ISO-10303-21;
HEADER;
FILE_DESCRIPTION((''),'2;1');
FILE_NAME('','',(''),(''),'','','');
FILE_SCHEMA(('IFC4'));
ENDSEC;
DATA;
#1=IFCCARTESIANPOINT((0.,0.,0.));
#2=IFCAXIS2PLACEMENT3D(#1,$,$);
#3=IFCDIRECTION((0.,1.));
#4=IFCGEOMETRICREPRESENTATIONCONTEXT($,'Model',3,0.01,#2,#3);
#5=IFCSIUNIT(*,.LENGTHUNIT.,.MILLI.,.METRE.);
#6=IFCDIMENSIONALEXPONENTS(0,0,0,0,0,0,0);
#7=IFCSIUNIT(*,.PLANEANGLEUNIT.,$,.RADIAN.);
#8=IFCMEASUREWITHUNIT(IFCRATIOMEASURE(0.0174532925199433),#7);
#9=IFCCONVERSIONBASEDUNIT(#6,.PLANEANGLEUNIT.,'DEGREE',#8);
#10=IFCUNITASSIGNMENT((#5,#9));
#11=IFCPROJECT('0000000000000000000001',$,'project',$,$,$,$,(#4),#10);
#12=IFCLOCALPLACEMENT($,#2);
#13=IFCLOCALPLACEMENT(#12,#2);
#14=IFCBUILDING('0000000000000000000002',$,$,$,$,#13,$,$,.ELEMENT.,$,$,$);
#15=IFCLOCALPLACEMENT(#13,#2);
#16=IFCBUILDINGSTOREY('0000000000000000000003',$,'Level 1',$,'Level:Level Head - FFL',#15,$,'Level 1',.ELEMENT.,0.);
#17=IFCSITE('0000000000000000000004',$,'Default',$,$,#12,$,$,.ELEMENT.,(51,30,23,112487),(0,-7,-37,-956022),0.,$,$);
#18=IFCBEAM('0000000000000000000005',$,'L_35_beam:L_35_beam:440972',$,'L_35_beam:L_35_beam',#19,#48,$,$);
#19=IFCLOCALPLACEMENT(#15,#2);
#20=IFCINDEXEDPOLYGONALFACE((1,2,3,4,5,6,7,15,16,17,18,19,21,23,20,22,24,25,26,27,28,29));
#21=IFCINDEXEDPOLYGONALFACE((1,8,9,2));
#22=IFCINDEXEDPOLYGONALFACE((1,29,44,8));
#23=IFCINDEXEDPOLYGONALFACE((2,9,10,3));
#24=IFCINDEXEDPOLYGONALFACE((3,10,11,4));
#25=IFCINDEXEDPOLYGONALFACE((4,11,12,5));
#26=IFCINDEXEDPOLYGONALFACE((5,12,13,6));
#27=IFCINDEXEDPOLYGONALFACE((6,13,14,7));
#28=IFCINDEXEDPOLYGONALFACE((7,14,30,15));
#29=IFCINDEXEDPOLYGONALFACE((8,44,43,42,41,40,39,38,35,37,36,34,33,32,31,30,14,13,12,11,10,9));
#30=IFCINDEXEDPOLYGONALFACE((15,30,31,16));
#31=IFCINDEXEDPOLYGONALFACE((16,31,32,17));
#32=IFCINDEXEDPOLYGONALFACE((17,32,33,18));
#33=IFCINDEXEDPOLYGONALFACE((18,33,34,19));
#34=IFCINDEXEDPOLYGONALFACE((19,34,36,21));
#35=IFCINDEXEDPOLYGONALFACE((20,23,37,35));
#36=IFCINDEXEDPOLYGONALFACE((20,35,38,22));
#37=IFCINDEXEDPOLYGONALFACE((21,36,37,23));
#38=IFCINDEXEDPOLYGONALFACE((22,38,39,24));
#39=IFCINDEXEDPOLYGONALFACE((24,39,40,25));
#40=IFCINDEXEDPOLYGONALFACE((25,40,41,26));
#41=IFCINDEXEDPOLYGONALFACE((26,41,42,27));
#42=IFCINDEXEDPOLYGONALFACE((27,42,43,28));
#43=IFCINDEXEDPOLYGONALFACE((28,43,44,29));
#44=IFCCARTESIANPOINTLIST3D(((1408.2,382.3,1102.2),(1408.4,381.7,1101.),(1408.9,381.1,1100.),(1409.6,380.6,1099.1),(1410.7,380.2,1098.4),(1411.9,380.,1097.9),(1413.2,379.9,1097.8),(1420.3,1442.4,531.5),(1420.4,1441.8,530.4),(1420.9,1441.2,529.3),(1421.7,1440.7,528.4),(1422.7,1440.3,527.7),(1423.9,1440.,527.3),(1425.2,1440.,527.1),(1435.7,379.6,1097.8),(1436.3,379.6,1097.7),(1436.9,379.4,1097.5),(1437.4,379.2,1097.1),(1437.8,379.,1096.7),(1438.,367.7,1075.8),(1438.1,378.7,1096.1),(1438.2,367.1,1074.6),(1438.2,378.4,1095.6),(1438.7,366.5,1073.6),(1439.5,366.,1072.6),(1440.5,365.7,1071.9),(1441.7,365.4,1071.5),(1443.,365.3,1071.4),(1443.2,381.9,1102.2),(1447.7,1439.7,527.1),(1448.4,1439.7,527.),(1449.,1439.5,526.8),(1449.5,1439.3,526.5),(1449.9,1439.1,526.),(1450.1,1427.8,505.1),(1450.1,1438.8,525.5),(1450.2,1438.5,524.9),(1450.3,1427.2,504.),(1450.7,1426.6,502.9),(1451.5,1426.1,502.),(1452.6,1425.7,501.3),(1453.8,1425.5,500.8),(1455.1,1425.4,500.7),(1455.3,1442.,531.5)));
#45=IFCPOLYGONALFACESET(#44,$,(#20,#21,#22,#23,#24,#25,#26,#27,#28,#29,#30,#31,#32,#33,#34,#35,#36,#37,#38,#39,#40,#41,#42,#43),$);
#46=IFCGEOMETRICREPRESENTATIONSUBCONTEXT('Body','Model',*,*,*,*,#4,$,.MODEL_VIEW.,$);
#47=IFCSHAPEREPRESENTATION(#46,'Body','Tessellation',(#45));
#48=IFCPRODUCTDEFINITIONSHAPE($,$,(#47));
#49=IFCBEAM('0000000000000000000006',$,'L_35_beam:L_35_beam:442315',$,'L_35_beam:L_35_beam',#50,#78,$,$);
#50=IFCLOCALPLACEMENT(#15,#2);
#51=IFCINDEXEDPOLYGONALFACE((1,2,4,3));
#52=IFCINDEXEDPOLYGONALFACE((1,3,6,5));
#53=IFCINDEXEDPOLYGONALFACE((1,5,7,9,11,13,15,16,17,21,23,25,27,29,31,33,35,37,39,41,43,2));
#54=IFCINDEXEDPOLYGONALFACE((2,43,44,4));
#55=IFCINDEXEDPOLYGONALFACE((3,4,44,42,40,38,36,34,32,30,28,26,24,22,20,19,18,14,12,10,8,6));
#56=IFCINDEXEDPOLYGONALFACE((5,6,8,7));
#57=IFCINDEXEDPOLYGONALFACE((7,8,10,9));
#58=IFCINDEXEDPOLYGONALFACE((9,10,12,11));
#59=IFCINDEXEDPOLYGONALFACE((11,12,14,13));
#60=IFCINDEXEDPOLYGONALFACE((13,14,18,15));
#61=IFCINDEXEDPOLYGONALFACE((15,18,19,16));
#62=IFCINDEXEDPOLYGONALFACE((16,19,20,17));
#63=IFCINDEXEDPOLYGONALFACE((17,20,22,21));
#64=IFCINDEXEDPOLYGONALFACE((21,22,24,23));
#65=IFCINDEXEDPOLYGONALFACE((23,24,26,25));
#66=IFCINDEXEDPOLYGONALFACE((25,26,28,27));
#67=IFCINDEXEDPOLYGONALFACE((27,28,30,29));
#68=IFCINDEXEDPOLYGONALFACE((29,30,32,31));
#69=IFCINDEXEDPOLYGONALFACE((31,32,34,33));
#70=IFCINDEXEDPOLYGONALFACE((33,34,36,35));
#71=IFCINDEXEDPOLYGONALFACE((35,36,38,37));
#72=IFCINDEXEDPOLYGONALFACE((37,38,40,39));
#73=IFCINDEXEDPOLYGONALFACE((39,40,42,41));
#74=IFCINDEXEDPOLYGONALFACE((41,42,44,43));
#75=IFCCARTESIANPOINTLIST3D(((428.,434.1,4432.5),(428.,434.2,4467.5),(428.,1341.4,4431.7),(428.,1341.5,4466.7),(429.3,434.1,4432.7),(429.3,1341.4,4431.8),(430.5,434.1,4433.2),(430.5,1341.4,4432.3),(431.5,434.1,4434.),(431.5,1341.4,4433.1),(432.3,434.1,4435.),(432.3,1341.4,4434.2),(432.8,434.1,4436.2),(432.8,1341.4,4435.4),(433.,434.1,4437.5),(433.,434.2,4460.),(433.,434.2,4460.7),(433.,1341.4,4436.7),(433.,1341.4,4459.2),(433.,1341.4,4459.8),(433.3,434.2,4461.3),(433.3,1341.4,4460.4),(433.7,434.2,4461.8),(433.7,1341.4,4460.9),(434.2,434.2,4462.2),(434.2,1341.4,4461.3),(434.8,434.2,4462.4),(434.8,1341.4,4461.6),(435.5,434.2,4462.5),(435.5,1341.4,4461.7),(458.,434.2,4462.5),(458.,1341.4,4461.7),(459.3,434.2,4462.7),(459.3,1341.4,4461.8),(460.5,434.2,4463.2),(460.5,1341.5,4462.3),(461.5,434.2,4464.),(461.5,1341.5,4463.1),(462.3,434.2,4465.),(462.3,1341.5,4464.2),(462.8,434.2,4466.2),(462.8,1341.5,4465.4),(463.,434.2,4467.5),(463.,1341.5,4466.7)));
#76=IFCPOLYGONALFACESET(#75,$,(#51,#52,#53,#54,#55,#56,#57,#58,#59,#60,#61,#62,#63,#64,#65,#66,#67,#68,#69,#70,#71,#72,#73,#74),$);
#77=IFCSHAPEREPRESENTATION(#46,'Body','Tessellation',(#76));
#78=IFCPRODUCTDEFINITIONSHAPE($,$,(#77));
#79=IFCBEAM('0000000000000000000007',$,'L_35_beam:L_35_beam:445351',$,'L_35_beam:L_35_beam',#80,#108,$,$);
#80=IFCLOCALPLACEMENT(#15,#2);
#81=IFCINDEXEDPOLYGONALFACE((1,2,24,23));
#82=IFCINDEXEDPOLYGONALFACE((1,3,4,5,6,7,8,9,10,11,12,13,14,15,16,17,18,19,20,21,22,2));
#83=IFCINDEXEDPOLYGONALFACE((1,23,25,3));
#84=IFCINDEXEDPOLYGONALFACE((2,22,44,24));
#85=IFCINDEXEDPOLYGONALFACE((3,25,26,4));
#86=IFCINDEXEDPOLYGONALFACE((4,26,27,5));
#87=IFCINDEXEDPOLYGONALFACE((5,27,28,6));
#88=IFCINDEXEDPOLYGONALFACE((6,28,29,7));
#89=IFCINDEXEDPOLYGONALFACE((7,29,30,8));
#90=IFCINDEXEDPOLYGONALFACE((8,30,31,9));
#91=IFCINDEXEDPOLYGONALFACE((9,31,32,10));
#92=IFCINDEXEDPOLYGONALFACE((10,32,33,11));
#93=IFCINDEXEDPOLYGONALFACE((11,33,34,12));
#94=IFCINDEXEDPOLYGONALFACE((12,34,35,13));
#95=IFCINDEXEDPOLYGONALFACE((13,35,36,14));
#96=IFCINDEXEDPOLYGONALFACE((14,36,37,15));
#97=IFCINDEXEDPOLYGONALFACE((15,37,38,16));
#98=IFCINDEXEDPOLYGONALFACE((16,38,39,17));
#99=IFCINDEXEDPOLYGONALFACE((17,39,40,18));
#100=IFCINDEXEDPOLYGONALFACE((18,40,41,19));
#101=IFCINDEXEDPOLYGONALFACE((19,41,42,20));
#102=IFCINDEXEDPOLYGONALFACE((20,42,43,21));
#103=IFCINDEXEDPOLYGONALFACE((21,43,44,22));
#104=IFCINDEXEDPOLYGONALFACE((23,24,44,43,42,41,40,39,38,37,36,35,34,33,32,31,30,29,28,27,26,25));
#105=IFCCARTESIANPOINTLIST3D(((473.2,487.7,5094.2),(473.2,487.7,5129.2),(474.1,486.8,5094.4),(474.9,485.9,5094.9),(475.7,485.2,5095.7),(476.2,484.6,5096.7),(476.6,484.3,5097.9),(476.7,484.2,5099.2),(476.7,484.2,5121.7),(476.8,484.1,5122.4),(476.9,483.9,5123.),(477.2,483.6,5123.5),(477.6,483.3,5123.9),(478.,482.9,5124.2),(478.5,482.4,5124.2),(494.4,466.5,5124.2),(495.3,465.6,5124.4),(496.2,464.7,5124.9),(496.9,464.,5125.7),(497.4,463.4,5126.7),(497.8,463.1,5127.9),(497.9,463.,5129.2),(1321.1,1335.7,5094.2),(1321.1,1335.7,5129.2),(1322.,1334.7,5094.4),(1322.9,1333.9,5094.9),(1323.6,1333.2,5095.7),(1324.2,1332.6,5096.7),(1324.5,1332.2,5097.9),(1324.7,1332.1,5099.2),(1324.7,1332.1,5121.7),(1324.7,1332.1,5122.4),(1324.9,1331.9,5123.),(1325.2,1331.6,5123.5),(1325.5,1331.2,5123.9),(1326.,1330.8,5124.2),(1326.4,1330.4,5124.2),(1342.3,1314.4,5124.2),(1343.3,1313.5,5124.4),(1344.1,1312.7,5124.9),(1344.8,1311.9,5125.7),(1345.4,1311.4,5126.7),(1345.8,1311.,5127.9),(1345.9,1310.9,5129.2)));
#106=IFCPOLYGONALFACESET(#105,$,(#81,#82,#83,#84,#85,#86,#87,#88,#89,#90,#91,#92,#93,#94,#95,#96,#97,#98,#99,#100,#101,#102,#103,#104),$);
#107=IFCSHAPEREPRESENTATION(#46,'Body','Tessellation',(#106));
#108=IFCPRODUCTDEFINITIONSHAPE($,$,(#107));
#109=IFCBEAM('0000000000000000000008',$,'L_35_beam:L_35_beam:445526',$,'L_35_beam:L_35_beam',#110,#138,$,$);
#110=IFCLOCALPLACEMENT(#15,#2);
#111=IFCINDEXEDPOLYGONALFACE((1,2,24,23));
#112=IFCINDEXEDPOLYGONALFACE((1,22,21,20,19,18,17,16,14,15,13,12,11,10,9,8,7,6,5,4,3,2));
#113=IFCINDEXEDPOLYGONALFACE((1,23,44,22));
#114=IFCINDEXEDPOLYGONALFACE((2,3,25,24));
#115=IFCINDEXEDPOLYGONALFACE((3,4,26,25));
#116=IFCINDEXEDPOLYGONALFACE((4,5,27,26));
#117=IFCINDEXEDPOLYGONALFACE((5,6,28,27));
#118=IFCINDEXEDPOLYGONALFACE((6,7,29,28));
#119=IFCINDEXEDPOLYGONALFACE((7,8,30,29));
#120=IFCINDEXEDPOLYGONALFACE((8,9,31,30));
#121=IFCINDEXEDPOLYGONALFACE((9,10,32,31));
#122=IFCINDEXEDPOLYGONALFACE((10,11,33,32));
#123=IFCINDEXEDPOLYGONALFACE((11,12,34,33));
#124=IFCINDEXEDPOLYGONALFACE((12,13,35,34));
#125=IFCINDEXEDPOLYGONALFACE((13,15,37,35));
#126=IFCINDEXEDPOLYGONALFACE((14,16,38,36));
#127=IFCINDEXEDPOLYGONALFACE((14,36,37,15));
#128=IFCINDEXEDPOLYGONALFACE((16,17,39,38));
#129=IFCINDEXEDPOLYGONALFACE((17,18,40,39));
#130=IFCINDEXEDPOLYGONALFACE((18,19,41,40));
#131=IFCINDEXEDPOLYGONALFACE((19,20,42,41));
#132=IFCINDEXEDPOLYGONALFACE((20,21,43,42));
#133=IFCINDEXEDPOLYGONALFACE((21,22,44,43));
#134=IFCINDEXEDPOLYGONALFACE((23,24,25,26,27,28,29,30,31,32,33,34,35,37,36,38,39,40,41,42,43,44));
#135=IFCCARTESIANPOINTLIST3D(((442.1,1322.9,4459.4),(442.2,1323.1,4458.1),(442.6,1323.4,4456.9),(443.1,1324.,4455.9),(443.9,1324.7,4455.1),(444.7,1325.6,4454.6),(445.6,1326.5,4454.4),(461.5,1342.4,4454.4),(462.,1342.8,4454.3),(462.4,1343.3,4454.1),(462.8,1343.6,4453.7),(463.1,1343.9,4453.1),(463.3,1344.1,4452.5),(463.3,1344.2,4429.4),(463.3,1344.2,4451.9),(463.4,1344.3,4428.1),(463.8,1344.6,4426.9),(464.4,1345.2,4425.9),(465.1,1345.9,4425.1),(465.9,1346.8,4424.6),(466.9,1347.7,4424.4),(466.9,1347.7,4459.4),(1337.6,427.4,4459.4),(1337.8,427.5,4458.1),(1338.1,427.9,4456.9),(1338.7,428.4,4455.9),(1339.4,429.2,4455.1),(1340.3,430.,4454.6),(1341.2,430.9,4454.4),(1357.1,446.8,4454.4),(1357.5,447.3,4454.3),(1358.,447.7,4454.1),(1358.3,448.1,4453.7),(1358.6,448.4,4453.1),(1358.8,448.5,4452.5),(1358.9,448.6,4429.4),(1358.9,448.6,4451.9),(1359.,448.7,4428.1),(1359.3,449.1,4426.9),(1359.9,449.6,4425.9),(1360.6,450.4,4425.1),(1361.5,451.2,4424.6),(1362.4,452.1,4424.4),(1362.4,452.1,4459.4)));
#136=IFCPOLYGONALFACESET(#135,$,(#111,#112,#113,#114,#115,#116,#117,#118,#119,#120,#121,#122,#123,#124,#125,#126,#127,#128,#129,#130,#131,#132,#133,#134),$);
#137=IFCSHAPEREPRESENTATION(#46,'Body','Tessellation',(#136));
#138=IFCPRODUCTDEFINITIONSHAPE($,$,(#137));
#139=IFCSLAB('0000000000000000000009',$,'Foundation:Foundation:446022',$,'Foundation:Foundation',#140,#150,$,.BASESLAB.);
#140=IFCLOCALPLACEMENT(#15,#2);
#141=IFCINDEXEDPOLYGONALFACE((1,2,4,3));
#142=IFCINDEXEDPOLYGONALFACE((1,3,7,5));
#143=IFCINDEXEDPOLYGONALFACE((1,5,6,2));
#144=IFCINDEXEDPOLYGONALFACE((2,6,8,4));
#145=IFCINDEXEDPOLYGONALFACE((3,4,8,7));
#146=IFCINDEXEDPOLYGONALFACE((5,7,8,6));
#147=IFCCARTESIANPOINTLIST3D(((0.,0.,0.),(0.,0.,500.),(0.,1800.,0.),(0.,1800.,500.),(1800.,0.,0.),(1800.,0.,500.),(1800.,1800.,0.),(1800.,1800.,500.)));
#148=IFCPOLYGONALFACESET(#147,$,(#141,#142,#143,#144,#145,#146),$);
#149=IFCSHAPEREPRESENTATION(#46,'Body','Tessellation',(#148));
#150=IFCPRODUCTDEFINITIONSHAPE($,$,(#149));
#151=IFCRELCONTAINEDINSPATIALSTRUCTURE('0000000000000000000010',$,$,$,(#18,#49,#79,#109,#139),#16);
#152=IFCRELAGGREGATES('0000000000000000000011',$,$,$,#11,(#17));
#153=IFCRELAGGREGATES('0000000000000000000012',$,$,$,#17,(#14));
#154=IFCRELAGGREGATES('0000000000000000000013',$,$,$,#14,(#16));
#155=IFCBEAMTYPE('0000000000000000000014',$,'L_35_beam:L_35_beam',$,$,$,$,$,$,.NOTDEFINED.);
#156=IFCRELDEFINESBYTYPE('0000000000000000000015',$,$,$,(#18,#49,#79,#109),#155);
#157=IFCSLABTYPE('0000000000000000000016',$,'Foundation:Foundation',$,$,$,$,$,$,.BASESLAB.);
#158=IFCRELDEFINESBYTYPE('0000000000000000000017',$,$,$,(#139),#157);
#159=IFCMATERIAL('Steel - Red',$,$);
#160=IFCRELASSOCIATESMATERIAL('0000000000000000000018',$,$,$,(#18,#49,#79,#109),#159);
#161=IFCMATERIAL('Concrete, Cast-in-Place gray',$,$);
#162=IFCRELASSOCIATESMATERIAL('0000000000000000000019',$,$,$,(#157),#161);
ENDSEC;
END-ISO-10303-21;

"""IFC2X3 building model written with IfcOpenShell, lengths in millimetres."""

from ifc_helpers import new_model, entity, si_unit, converted_unit, direction, frame, frame_2d, origin, origin_2d_with_axis, place, context, subcontext, project, spatial, polyline, circle_curve, parameter, trimmed, segment, composite_curve, rectangle, outline, extrude, material, type_object, element, save


model = new_model("IFC2X3")

# Units and contexts
model_context = context("Model", 3, precision=0.01, world=origin(), true_north=direction((0.0, 1.0)))
body_context = subcontext(model_context, "Body", "Model", "MODEL_VIEW")
ifc_project = project(units=[si_unit("LENGTHUNIT", "METRE", prefix="MILLI"), converted_unit("PLANEANGLEUNIT", "DEGREE", entity("IfcRatioMeasure", 0.0174532925199433), si_unit("PLANEANGLEUNIT", "RADIAN"), dimensions=[0, 0, 0, 0, 0, 0, 0])], contexts=[model_context])

# Site, building, storey
site_placement = place(None, origin())
site = spatial("IfcSite", under=ifc_project, at=site_placement, Name="Default", CompositionType="ELEMENT", RefLatitude=(51, 30, 23, 112487), RefLongitude=(0, -7, -37, -956022), RefElevation=0.0)
building_placement = place(site_placement, origin())
building = spatial("IfcBuilding", under=site, at=building_placement, CompositionType="ELEMENT")
storey_placement = place(building_placement, origin())
storey = spatial("IfcBuildingStorey", under=building, at=storey_placement, Name="Level 1", ObjectType="Level:Level Head - FFL", LongName="Level 1", CompositionType="ELEMENT", Elevation=0.0)

# Beams
ifc_material_1 = material(Name="Steel - Red")
beam_type = type_object("IfcBeamType", Name="L_35_beam:L_35_beam", PredefinedType="NOTDEFINED")
beam_1_placement = place(storey_placement, frame((1463.5, 1463.5, 500.0), z_axis=(0.005391, 0.473951, 0.880535), x_axis=(-0.010015, -0.880478, 0.473982)))
element("IfcBeam", 1, at=beam_1_placement, inside=storey, type_object=beam_type, material=ifc_material_1, Name="L_35_beam:L_35_beam:440972", ObjectType="L_35_beam:L_35_beam", context=body_context, shape_type="SweptSolid", body=[
    extrude(outline(composite_curve([segment(polyline([(-23.2, -11.8), (11.8, -11.8)]), True, "CONTINUOUS"), segment(polyline([(11.8, -11.8), (11.8, 23.2)]), True, "CONTINUOUS"), segment(trimmed(circle_curve(frame_2d((11.8, 18.2), x_axis=(0.0, 1.0)), 5.0), [parameter(0.0)], [parameter(90.0)], True, "PARAMETER"), True, "CONTINUOUS"), segment(polyline([(6.8, 18.2), (6.8, -4.3)]), True, "CONTINUOUS"), segment(trimmed(circle_curve(frame_2d((4.3, -4.3), x_axis=(1.0, 0.0)), 2.5), [parameter(270.0)], [parameter(0.0)], True, "PARAMETER"), False, "CONTINUOUS"), segment(polyline([(4.3, -6.8), (-18.2, -6.8)]), True, "CONTINUOUS"), segment(trimmed(circle_curve(frame_2d((-18.2, -11.8), x_axis=(0.0, 1.0)), 5.0), [parameter(0.0)], [parameter(90.0)], True, "PARAMETER"), True, "CONTINUOUS")], self_intersect=False)), frame((34.0, -19.8, 5.7), z_axis=(1.0, 0.0, 0.0), x_axis=(0.0, 0.0, 1.0)), (0.0, 0.0, 1.0), 1204.0),
])
beam_2_placement = place(storey_placement, frame((420.0, 420.0, 4450.0), z_axis=(0.0, 0.000952, 1.0), x_axis=(0.0, 1.0, -0.000952)))
element("IfcBeam", 2, at=beam_2_placement, inside=storey, type_object=beam_type, material=ifc_material_1, Name="L_35_beam:L_35_beam:442315", ObjectType="L_35_beam:L_35_beam", context=body_context, shape_type="SweptSolid", body=[
    extrude(outline(composite_curve([segment(polyline([(-23.2, -11.8), (11.8, -11.8)]), True, "CONTINUOUS"), segment(polyline([(11.8, -11.8), (11.8, 23.2)]), True, "CONTINUOUS"), segment(trimmed(circle_curve(frame_2d((11.8, 18.2), x_axis=(0.0, 1.0)), 5.0), [parameter(0.0)], [parameter(90.0)], True, "PARAMETER"), True, "CONTINUOUS"), segment(polyline([(6.8, 18.2), (6.8, -4.3)]), True, "CONTINUOUS"), segment(trimmed(circle_curve(frame_2d((4.3, -4.3), x_axis=(1.0, 0.0)), 2.5), [parameter(270.0)], [parameter(0.0)], True, "PARAMETER"), False, "CONTINUOUS"), segment(polyline([(4.3, -6.8), (-18.2, -6.8)]), True, "CONTINUOUS"), segment(trimmed(circle_curve(frame_2d((-18.2, -11.8), x_axis=(0.0, 1.0)), 5.0), [parameter(0.0)], [parameter(90.0)], True, "PARAMETER"), True, "CONTINUOUS")], self_intersect=False)), frame((14.2, -19.8, 5.7), z_axis=(1.0, 0.0, 0.0), x_axis=(0.0, 0.0, 1.0)), (0.0, 0.0, 1.0), 907.3),
])
beam_3_placement = place(storey_placement, frame((434.1, 434.1, 5119.0), z_axis=(0.0, 0.0, 1.0), x_axis=(0.707107, 0.707107, 0.0)))
element("IfcBeam", 3, at=beam_3_placement, inside=storey, type_object=beam_type, material=ifc_material_1, Name="L_35_beam:L_35_beam:445351", ObjectType="L_35_beam:L_35_beam", context=body_context, shape_type="SweptSolid", body=[
    extrude(outline(composite_curve([segment(polyline([(-23.2, -11.8), (11.8, -11.8)]), True, "CONTINUOUS"), segment(polyline([(11.8, -11.8), (11.8, 23.2)]), True, "CONTINUOUS"), segment(trimmed(circle_curve(frame_2d((11.8, 18.2), x_axis=(0.0, 1.0)), 5.0), [parameter(0.0)], [parameter(90.0)], True, "PARAMETER"), True, "CONTINUOUS"), segment(polyline([(6.8, 18.2), (6.8, -4.3)]), True, "CONTINUOUS"), segment(trimmed(circle_curve(frame_2d((4.3, -4.3), x_axis=(1.0, 0.0)), 2.5), [parameter(270.0)], [parameter(0.0)], True, "PARAMETER"), False, "CONTINUOUS"), segment(polyline([(4.3, -6.8), (-18.2, -6.8)]), True, "CONTINUOUS"), segment(trimmed(circle_curve(frame_2d((-18.2, -11.8), x_axis=(0.0, 1.0)), 5.0), [parameter(0.0)], [parameter(90.0)], True, "PARAMETER"), True, "CONTINUOUS")], self_intersect=False)), frame((65.5, -1.5, -1.5), z_axis=(1.0, 0.0, 0.0), x_axis=(0.0, 0.0, 1.0)), (0.0, 0.0, 1.0), 1199.2),
])
beam_4_placement = place(storey_placement, frame((420.0, 1380.1, 4449.1), z_axis=(0.0, 0.0, 1.0), x_axis=(0.7071, -0.707114, 0.0)))
element("IfcBeam", 4, at=beam_4_placement, inside=storey, type_object=beam_type, material=ifc_material_1, Name="L_35_beam:L_35_beam:445526", ObjectType="L_35_beam:L_35_beam", context=body_context, shape_type="SweptSolid", body=[
    extrude(outline(composite_curve([segment(polyline([(-23.2, -11.8), (11.8, -11.8)]), True, "CONTINUOUS"), segment(polyline([(11.8, -11.8), (11.8, 23.2)]), True, "CONTINUOUS"), segment(trimmed(circle_curve(frame_2d((11.8, 18.2), x_axis=(0.0, 1.0)), 5.0), [parameter(0.0)], [parameter(90.0)], True, "PARAMETER"), True, "CONTINUOUS"), segment(polyline([(6.8, 18.2), (6.8, -4.3)]), True, "CONTINUOUS"), segment(trimmed(circle_curve(frame_2d((4.3, -4.3), x_axis=(1.0, 0.0)), 2.5), [parameter(270.0)], [parameter(0.0)], True, "PARAMETER"), False, "CONTINUOUS"), segment(polyline([(4.3, -6.8), (-18.2, -6.8)]), True, "CONTINUOUS"), segment(trimmed(circle_curve(frame_2d((-18.2, -11.8), x_axis=(0.0, 1.0)), 5.0), [parameter(0.0)], [parameter(90.0)], True, "PARAMETER"), True, "CONTINUOUS")], self_intersect=False)), frame((56.0, -1.5, -1.5), z_axis=(1.0, 0.0, 0.0), x_axis=(0.0, 0.0, 1.0)), (0.0, 0.0, 1.0), 1266.5),
])

# Slab
ifc_material_2 = material(Name="Concrete, Cast-in-Place gray")
slab_type = type_object("IfcSlabType", Name="Foundation:Foundation", PredefinedType="BASESLAB", material=ifc_material_2)
slab_placement = place(storey_placement, origin())
element("IfcSlab", 5, at=slab_placement, inside=storey, type_object=slab_type, Name="Foundation:Foundation:446022", ObjectType="Foundation:Foundation", PredefinedType="BASESLAB", context=body_context, shape_type="SweptSolid", body=[
    extrude(rectangle(XDim=1800.0, YDim=1800.0, at=origin_2d_with_axis()), frame((900.0, 900.0, 0.0), z_axis=(0.0, 0.0, 1.0), x_axis=(0.0, -1.0, 0.0)), (0.0, 0.0, 1.0), 500.0),
])

save(model, "model.ifc")
